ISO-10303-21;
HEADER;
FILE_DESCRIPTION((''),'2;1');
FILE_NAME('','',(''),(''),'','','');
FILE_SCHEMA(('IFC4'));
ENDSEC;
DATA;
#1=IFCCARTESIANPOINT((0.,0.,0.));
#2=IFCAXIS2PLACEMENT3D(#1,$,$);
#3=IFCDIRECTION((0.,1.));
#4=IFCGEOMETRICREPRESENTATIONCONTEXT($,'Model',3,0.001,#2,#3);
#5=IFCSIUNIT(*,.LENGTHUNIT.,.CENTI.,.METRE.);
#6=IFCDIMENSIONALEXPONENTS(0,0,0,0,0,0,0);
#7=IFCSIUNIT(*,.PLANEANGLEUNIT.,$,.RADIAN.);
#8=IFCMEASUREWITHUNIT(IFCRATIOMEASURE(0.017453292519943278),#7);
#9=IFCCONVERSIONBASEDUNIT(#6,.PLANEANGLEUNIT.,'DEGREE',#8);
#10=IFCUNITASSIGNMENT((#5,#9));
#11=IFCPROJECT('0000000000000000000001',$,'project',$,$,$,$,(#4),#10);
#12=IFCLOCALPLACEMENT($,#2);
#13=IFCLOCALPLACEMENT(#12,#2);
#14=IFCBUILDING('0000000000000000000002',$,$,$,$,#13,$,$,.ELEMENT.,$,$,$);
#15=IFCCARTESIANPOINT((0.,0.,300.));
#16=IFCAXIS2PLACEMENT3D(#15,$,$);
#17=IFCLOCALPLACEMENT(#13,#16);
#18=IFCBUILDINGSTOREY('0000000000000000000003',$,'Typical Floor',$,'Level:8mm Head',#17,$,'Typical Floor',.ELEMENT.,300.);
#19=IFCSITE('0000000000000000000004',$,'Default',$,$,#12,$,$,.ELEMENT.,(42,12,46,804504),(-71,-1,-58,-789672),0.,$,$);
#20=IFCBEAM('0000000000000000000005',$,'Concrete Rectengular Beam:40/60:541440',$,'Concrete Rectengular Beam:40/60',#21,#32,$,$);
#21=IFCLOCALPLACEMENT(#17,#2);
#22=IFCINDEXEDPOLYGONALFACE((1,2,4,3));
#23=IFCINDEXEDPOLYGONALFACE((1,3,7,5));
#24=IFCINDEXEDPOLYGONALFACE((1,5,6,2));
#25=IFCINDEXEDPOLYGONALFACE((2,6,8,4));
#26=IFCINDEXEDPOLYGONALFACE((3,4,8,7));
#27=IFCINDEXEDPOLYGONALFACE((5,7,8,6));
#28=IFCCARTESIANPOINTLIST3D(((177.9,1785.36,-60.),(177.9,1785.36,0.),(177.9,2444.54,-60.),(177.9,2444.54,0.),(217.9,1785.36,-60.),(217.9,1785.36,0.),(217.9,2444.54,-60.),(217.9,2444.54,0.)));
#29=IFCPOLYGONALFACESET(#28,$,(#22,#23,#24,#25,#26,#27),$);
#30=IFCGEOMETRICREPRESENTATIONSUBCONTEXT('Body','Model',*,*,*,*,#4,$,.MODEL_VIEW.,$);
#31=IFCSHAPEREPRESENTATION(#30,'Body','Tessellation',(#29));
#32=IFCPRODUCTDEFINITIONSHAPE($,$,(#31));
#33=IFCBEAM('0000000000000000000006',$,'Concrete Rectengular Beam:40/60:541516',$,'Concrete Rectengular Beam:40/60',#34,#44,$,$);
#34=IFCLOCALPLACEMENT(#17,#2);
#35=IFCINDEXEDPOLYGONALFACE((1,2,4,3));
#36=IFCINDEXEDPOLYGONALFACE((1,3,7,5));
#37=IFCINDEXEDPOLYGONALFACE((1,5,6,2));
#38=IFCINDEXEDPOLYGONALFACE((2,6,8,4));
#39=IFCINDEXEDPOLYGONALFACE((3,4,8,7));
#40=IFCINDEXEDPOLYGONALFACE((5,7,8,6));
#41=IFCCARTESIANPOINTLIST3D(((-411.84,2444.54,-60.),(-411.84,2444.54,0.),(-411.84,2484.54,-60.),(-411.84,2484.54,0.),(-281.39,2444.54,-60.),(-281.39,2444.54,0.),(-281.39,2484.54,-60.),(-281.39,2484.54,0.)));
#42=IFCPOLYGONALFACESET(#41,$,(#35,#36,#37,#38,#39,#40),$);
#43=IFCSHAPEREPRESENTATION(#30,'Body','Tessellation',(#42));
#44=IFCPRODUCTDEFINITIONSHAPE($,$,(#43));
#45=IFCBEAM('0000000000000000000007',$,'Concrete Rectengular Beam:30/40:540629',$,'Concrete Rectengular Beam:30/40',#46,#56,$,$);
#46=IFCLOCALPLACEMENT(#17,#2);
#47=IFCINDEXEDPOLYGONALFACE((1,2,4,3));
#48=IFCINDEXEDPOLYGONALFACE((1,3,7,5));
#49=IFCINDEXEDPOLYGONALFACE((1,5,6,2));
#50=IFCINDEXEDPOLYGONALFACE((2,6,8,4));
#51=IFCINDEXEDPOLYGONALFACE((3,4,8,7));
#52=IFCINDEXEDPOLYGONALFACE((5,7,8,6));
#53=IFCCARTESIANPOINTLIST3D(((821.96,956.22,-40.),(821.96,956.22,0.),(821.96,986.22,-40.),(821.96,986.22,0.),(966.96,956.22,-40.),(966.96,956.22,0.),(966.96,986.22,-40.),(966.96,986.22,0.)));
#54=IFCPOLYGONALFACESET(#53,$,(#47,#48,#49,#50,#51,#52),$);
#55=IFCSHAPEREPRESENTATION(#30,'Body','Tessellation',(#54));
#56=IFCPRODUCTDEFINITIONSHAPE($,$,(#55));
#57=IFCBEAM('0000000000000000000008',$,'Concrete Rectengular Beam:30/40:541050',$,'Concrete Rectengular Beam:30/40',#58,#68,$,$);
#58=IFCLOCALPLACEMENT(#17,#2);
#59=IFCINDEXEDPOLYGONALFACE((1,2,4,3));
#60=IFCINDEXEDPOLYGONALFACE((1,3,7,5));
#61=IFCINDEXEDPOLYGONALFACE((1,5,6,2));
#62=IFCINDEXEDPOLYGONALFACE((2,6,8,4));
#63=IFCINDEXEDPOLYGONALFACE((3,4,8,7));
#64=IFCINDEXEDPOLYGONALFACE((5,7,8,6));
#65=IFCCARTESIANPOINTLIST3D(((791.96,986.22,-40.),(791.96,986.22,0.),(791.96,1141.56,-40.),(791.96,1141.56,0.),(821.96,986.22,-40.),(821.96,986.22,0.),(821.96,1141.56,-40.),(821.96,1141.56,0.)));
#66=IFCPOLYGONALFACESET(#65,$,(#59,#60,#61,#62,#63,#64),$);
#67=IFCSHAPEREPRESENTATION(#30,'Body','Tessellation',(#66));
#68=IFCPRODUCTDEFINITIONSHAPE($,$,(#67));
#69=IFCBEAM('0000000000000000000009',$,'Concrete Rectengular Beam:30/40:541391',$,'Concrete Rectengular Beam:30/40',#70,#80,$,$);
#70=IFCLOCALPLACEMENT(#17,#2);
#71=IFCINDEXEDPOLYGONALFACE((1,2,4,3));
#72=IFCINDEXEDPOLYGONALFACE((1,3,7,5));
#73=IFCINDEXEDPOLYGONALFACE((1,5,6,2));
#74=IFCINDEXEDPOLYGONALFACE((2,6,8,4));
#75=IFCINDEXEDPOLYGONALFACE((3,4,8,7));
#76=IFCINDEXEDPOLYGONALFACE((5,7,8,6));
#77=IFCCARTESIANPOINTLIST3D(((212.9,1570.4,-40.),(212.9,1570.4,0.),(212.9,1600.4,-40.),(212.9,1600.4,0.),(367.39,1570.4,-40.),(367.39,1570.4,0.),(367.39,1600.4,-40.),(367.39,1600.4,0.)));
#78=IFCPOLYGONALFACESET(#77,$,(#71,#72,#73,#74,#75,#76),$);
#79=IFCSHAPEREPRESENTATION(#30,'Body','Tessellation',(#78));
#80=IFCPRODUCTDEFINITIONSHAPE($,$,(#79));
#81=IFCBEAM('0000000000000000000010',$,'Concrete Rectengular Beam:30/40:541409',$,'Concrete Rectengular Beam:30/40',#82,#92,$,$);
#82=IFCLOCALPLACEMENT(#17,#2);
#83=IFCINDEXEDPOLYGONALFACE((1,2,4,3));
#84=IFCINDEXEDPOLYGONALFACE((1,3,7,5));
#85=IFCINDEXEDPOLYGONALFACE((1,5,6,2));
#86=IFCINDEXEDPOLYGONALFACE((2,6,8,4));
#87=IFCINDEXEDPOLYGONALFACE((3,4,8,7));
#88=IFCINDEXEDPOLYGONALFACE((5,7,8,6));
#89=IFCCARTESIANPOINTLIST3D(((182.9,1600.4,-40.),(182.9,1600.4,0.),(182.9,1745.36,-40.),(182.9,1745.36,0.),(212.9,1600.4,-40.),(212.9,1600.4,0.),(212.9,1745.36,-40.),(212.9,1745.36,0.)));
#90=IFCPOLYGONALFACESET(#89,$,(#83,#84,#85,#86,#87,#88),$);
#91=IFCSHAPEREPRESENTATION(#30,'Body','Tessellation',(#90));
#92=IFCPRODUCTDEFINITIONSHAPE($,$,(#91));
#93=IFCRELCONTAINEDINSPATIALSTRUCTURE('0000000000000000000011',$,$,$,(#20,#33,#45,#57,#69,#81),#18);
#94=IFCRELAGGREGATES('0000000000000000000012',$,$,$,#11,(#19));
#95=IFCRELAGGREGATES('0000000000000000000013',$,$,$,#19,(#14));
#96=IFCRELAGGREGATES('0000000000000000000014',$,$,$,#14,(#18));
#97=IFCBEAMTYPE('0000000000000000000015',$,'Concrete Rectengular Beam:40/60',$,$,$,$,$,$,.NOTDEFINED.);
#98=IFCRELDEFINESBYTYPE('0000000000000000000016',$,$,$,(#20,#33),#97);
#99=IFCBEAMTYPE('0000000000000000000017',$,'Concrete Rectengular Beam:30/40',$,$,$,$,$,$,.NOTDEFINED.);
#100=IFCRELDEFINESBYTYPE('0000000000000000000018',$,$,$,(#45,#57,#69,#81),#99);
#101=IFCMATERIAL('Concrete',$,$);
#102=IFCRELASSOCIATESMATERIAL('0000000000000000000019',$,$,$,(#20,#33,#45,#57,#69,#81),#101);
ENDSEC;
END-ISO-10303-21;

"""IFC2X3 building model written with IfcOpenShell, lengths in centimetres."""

from ifc_helpers import new_model, entity, si_unit, converted_unit, direction, frame, frame_2d, origin, origin_2d_with_axis, place, context, subcontext, project, spatial, rectangle, extrude, material, type_object, element, save


model = new_model("IFC2X3")

# Units and contexts
model_context = context("Model", 3, precision=0.001, world=origin(), true_north=direction((0.0, 1.0)))
body_context = subcontext(model_context, "Body", "Model", "MODEL_VIEW")
ifc_project = project(units=[si_unit("LENGTHUNIT", "METRE", prefix="CENTI"), converted_unit("PLANEANGLEUNIT", "DEGREE", entity("IfcRatioMeasure", 0.017453292519943278), si_unit("PLANEANGLEUNIT", "RADIAN"), dimensions=[0, 0, 0, 0, 0, 0, 0])], contexts=[model_context])

# Site, building, storey
site_placement = place(None, origin())
site = spatial("IfcSite", under=ifc_project, at=site_placement, Name="Default", CompositionType="ELEMENT", RefLatitude=(42, 12, 46, 804504), RefLongitude=(-71, -1, -58, -789672), RefElevation=0.0)
building_placement = place(site_placement, origin())
building = spatial("IfcBuilding", under=site, at=building_placement, CompositionType="ELEMENT")
storey_placement = place(building_placement, frame((0.0, 0.0, 300.0)))
storey = spatial("IfcBuildingStorey", under=building, at=storey_placement, Name="Typical Floor", ObjectType="Level:8mm Head", LongName="Typical Floor", CompositionType="ELEMENT", Elevation=300.0)

# Beams
ifc_material = material(Name="Concrete")
beam_type_1 = type_object("IfcBeamType", Name="Concrete Rectengular Beam:40/60", PredefinedType="NOTDEFINED")
beam_1_placement = place(storey_placement, frame((197.9, 1765.36, 0.0), z_axis=(0.0, 0.0, 1.0), x_axis=(0.0, 1.0, 0.0)))
element("IfcBeam", 1, at=beam_1_placement, inside=storey, type_object=beam_type_1, material=ifc_material, Name="Concrete Rectengular Beam:40/60:541440", ObjectType="Concrete Rectengular Beam:40/60", context=body_context, shape_type="SweptSolid", body=[
    extrude(rectangle(XDim=60.0, YDim=40.0, at=frame_2d((0.0, 0.0), x_axis=(1.0, 0.0))), frame((20.0, 0.0, -30.0), z_axis=(1.0, 0.0, 0.0), x_axis=(0.0, 0.0, -1.0)), (0.0, 0.0, 1.0), 659.18),
])
beam_2_placement = place(storey_placement, frame((-261.39, 2464.54, 0.0), z_axis=(0.0, 0.0, 1.0), x_axis=(-1.0, 0.0, 0.0)))
element("IfcBeam", 2, at=beam_2_placement, inside=storey, type_object=beam_type_1, material=ifc_material, Name="Concrete Rectengular Beam:40/60:541516", ObjectType="Concrete Rectengular Beam:40/60", context=body_context, shape_type="SweptSolid", body=[
    extrude(rectangle(XDim=60.0, YDim=40.0, at=frame_2d((0.0, 0.0), x_axis=(1.0, 0.0))), frame((20.0, 0.0, -30.0), z_axis=(1.0, 0.0, 0.0), x_axis=(0.0, 0.0, -1.0)), (0.0, 0.0, 1.0), 130.45),
])
beam_type_2 = type_object("IfcBeamType", Name="Concrete Rectengular Beam:30/40", PredefinedType="NOTDEFINED")
beam_3_placement = place(storey_placement, frame((986.96, 971.22, 0.0), z_axis=(0.0, 0.0, 1.0), x_axis=(-1.0, 0.0, 0.0)))
element("IfcBeam", 3, at=beam_3_placement, inside=storey, type_object=beam_type_2, material=ifc_material, Name="Concrete Rectengular Beam:30/40:540629", ObjectType="Concrete Rectengular Beam:30/40", context=body_context, shape_type="SweptSolid", body=[
    extrude(rectangle(XDim=40.0, YDim=30.0, at=frame_2d((0.0, 0.0), x_axis=(1.0, 0.0))), frame((20.0, 0.0, -20.0), z_axis=(1.0, 0.0, 0.0), x_axis=(0.0, 0.0, -1.0)), (0.0, 0.0, 1.0), 145.0),
])
beam_4_placement = place(storey_placement, frame((806.96, 971.22, 0.0), z_axis=(0.0, 0.0, 1.0), x_axis=(0.0, 1.0, 0.0)))
element("IfcBeam", 4, at=beam_4_placement, inside=storey, type_object=beam_type_2, material=ifc_material, Name="Concrete Rectengular Beam:30/40:541050", ObjectType="Concrete Rectengular Beam:30/40", context=body_context, shape_type="SweptSolid", body=[
    extrude(rectangle(XDim=40.0, YDim=30.0, at=origin_2d_with_axis()), frame((15.0, 0.0, -20.0), z_axis=(1.0, 0.0, 0.0), x_axis=(0.0, 0.0, -1.0)), (0.0, 0.0, 1.0), 155.34),
])
beam_5_placement = place(storey_placement, frame((382.39, 1585.4, 0.0), z_axis=(0.0, 0.0, 1.0), x_axis=(-1.0, 0.0, 0.0)))
element("IfcBeam", 5, at=beam_5_placement, inside=storey, type_object=beam_type_2, material=ifc_material, Name="Concrete Rectengular Beam:30/40:541391", ObjectType="Concrete Rectengular Beam:30/40", context=body_context, shape_type="SweptSolid", body=[
    extrude(rectangle(XDim=40.0, YDim=30.0, at=frame_2d((0.0, 0.0), x_axis=(1.0, 0.0))), frame((15.0, 0.0, -20.0), z_axis=(1.0, 0.0, 0.0), x_axis=(0.0, 0.0, -1.0)), (0.0, 0.0, 1.0), 154.49),
])
beam_6_placement = place(storey_placement, frame((197.9, 1585.4, 0.0), z_axis=(0.0, 0.0, 1.0), x_axis=(0.0, 1.0, 0.0)))
element("IfcBeam", 6, at=beam_6_placement, inside=storey, type_object=beam_type_2, material=ifc_material, Name="Concrete Rectengular Beam:30/40:541409", ObjectType="Concrete Rectengular Beam:30/40", context=body_context, shape_type="SweptSolid", body=[
    extrude(rectangle(XDim=40.0, YDim=30.0, at=origin_2d_with_axis()), frame((15.0, 0.0, -20.0), z_axis=(1.0, 0.0, 0.0), x_axis=(0.0, 0.0, -1.0)), (0.0, 0.0, 1.0), 144.96),
])

save(model, "model.ifc")
